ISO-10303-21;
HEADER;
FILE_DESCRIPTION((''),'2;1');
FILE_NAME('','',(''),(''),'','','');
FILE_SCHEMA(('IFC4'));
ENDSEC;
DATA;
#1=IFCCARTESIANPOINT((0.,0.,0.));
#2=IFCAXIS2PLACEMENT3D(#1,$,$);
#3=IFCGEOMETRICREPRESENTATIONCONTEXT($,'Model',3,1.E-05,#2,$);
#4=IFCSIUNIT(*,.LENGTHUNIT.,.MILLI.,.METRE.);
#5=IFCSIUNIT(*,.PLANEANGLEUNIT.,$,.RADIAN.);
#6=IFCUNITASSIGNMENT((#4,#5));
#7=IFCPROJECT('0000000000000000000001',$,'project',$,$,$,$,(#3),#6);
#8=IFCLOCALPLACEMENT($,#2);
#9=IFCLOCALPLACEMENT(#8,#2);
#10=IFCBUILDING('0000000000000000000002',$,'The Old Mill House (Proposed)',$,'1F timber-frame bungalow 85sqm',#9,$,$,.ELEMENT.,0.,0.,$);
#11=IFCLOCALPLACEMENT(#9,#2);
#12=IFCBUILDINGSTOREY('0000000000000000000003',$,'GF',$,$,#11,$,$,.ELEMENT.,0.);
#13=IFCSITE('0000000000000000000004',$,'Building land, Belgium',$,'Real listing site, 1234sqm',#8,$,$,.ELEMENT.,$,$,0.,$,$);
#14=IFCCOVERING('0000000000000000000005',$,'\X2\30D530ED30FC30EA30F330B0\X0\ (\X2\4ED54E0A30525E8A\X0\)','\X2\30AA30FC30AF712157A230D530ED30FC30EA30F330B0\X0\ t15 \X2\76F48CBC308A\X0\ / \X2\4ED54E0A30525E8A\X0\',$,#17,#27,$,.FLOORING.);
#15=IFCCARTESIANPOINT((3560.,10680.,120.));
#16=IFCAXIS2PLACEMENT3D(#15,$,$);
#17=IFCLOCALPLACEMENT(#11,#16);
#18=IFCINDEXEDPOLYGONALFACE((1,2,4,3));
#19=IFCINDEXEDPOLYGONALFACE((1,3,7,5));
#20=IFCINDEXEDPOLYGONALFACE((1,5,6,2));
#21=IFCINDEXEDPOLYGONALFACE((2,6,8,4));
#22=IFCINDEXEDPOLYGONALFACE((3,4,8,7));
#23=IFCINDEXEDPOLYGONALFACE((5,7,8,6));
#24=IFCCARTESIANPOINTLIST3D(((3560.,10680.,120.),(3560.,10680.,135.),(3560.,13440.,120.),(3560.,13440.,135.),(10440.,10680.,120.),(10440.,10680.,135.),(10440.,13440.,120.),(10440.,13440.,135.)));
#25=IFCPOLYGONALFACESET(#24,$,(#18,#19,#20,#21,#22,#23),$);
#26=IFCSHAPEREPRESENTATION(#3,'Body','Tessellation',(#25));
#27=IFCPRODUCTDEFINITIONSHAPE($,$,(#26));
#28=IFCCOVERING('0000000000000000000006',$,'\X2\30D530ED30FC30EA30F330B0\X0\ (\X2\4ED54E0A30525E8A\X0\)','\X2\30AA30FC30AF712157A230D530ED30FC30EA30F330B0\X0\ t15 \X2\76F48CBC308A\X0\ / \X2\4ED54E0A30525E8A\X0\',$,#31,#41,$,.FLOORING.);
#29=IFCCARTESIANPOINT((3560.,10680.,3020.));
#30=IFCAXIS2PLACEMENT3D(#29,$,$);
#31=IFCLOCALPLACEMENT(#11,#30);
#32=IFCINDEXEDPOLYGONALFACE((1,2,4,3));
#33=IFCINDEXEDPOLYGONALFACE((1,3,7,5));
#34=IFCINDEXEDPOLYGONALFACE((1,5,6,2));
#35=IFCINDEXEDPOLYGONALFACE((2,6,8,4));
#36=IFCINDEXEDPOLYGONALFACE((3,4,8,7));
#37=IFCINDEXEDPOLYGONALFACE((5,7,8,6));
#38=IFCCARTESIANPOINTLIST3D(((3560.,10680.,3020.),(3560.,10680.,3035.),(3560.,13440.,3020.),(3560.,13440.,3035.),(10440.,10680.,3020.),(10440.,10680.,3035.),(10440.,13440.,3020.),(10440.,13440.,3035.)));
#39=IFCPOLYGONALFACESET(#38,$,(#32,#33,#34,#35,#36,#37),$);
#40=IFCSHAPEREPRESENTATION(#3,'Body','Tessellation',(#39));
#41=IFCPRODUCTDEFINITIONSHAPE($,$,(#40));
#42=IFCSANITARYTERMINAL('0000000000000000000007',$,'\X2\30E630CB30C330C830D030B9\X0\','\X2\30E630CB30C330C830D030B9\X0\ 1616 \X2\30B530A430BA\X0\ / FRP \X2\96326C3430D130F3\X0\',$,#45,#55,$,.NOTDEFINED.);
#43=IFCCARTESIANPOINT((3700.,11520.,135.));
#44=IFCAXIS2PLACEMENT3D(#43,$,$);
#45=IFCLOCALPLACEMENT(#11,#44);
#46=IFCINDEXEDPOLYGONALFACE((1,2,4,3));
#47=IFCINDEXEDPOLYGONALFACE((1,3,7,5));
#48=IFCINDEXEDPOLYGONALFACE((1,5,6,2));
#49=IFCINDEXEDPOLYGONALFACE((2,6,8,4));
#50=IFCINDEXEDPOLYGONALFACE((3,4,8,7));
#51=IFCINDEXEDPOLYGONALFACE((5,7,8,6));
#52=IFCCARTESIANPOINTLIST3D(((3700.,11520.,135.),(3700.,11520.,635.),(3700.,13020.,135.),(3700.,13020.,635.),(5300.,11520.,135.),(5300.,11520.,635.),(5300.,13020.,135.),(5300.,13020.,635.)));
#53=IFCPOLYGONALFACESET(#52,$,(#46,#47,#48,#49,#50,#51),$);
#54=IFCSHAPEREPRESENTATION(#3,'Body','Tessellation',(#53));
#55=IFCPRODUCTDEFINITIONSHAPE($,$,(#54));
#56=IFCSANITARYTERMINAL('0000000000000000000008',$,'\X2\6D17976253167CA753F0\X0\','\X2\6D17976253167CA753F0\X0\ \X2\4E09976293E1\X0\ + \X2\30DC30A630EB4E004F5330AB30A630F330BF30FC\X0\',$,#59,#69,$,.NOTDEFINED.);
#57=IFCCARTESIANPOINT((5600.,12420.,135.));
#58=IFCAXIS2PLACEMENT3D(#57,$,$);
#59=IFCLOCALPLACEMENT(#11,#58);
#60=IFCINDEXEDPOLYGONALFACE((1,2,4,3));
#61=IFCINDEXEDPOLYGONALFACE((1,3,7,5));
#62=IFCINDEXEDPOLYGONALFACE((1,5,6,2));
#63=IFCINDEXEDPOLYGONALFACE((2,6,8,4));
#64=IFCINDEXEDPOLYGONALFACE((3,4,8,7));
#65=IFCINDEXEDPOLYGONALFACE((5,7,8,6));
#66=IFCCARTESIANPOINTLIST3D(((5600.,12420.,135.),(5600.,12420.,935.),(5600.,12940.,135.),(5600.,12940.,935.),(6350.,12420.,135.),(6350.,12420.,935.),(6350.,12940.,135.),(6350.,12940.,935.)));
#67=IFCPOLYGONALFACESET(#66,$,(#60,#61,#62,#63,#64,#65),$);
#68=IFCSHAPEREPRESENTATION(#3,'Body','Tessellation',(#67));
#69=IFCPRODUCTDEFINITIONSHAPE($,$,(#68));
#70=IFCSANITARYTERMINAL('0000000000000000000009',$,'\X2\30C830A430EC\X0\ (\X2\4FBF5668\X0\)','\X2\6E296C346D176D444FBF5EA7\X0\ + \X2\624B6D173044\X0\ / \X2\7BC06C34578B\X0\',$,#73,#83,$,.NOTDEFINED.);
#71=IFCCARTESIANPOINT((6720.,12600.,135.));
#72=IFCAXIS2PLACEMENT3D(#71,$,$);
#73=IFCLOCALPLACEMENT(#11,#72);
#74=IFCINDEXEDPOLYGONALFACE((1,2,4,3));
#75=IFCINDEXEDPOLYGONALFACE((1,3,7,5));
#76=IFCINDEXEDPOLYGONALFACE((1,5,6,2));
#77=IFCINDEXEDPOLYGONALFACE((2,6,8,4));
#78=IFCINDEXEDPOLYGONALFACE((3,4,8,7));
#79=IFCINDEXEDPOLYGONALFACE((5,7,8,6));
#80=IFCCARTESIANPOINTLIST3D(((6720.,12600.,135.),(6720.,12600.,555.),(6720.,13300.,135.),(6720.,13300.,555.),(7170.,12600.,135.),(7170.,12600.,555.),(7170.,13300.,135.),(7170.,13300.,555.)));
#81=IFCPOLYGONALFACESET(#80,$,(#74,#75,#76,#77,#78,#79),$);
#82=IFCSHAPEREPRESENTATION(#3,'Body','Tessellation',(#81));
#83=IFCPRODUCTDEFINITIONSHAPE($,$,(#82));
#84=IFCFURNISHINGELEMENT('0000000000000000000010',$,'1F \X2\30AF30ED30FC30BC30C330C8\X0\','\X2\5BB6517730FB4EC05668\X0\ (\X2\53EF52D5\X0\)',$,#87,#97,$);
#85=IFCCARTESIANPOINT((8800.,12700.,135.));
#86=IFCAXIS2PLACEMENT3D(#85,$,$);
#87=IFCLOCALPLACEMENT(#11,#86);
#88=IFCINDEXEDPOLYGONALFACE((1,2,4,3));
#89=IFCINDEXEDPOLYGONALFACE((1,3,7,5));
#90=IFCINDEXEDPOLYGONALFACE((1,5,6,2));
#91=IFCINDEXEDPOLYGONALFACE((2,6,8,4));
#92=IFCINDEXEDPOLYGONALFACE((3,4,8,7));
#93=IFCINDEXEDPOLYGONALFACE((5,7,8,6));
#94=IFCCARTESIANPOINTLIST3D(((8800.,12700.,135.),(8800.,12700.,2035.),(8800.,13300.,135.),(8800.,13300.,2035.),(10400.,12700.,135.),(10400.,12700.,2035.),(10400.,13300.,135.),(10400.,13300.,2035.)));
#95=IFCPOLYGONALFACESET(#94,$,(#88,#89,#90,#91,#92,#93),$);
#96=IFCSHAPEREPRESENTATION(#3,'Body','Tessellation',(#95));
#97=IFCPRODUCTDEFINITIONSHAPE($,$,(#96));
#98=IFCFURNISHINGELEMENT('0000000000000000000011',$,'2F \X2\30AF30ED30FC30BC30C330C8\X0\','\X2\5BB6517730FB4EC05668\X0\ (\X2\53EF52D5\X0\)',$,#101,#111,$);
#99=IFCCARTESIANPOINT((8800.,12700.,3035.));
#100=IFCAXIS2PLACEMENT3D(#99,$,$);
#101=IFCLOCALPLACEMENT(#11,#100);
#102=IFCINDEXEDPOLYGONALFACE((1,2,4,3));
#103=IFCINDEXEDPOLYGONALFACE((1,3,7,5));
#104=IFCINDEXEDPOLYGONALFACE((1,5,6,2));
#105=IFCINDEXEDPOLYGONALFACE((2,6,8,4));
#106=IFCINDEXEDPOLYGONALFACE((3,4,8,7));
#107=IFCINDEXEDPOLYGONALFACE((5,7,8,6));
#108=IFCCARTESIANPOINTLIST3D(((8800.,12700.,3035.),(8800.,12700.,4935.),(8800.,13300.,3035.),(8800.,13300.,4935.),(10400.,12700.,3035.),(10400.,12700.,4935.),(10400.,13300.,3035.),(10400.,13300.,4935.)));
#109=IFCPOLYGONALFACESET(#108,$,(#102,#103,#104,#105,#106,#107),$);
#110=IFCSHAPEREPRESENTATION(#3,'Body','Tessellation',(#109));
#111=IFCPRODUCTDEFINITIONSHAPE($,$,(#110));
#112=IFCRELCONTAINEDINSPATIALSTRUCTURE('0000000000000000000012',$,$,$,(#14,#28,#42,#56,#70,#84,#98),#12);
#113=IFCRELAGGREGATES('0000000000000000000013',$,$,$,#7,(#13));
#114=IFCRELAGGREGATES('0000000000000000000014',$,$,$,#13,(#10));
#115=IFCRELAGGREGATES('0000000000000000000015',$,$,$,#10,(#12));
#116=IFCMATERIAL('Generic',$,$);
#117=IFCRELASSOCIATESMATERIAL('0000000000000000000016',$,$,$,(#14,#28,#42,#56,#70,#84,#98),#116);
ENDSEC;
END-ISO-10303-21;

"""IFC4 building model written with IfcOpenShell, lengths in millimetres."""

from ifc_helpers import new_model, si_unit, frame, frame_2d, origin, place, context, project, spatial, rectangle, extrude, material, element, save


model = new_model("IFC4")

# Units and contexts
model_context = context("Model", 3, precision=1e-05, world=origin())
ifc_project = project(units=[si_unit("LENGTHUNIT", "METRE", prefix="MILLI"), si_unit("PLANEANGLEUNIT", "RADIAN")], contexts=[model_context])

# Site, building, storey
site_placement = place(None, origin())
site = spatial("IfcSite", under=ifc_project, at=site_placement, Name="Building land, Belgium", ObjectType="Real listing site, 1234sqm", CompositionType="ELEMENT", RefElevation=0.0)
building_placement = place(site_placement, origin())
building = spatial("IfcBuilding", under=site, at=building_placement, Name="The Old Mill House (Proposed)", ObjectType="1F timber-frame bungalow 85sqm", CompositionType="ELEMENT", ElevationOfRefHeight=0.0, ElevationOfTerrain=0.0)
storey_placement = place(building_placement, origin())
storey = spatial("IfcBuildingStorey", under=building, at=storey_placement, Name="GF", CompositionType="ELEMENT", Elevation=0.0)

# Coverings
ifc_material_1 = material(Name="Generic")
covering_1_placement = place(storey_placement, frame((3560.0, 10680.0, 120.0)))
element("IfcCovering", 1, at=covering_1_placement, inside=storey, material=ifc_material_1, Name="フローリング (仕上げ床)", Description="オーク無垢フローリング t15 直貼り / 仕上げ床", PredefinedType="FLOORING", context=model_context, shape_type="SweptSolid", body=[
    extrude(rectangle(XDim=6880.0, YDim=2760.0, at=frame_2d((3440.0, 1380.0))), frame((3560.0, 10680.0, 120.0)), (0.0, 0.0, 1.0), 15.0),
])
covering_2_placement = place(storey_placement, frame((3560.0, 10680.0, 3020.0)))
element("IfcCovering", 2, at=covering_2_placement, inside=storey, material=ifc_material_1, Name="フローリング (仕上げ床)", Description="オーク無垢フローリング t15 直貼り / 仕上げ床", PredefinedType="FLOORING", context=model_context, shape_type="SweptSolid", body=[
    extrude(rectangle(XDim=6880.0, YDim=2760.0, at=frame_2d((3440.0, 1380.0))), frame((3560.0, 10680.0, 3020.0)), (0.0, 0.0, 1.0), 15.0),
])

# Sanitary terminals
sanitary_terminal_1_placement = place(storey_placement, frame((3700.0, 11520.0, 135.0)))
element("IfcSanitaryTerminal", 3, at=sanitary_terminal_1_placement, inside=storey, material=ifc_material_1, Name="ユニットバス", Description="ユニットバス 1616 サイズ / FRP 防水パン", PredefinedType="NOTDEFINED", context=model_context, shape_type="SweptSolid", body=[
    extrude(rectangle(XDim=1600.0, YDim=1500.0, at=frame_2d((800.0, 750.0))), frame((3700.0, 11520.0, 135.0)), (0.0, 0.0, 1.0), 500.0),
])
sanitary_terminal_2_placement = place(storey_placement, frame((5600.0, 12420.0, 135.0)))
element("IfcSanitaryTerminal", 4, at=sanitary_terminal_2_placement, inside=storey, material=ifc_material_1, Name="洗面化粧台", Description="洗面化粧台 三面鏡 + ボウル一体カウンター", PredefinedType="NOTDEFINED", context=model_context, shape_type="SweptSolid", body=[
    extrude(rectangle(XDim=750.0, YDim=520.0, at=frame_2d((375.0, 260.0))), frame((5600.0, 12420.0, 135.0)), (0.0, 0.0, 1.0), 800.0),
])
sanitary_terminal_3_placement = place(storey_placement, frame((6720.0, 12600.0, 135.0)))
element("IfcSanitaryTerminal", 5, at=sanitary_terminal_3_placement, inside=storey, material=ifc_material_1, Name="トイレ (便器)", Description="温水洗浄便座 + 手洗い / 節水型", PredefinedType="NOTDEFINED", context=model_context, shape_type="SweptSolid", body=[
    extrude(rectangle(XDim=450.0, YDim=700.0, at=frame_2d((225.0, 350.0))), frame((6720.0, 12600.0, 135.0)), (0.0, 0.0, 1.0), 420.0),
])

# Furnishing elements
furnishing_1_placement = place(storey_placement, frame((8800.0, 12700.0, 135.0)))
element("IfcFurnishingElement", 6, at=furnishing_1_placement, inside=storey, material=ifc_material_1, Name="1F クローゼット", Description="家具・什器 (可動)", context=model_context, shape_type="SweptSolid", body=[
    extrude(rectangle(XDim=1600.0, YDim=600.0, at=frame_2d((800.0, 300.0))), frame((8800.0, 12700.0, 135.0)), (0.0, 0.0, 1.0), 1900.0),
])
furnishing_2_placement = place(storey_placement, frame((8800.0, 12700.0, 3035.0)))
element("IfcFurnishingElement", 7, at=furnishing_2_placement, inside=storey, material=ifc_material_1, Name="2F クローゼット", Description="家具・什器 (可動)", context=model_context, shape_type="SweptSolid", body=[
    extrude(rectangle(XDim=1600.0, YDim=600.0, at=frame_2d((800.0, 300.0))), frame((8800.0, 12700.0, 3035.0)), (0.0, 0.0, 1.0), 1900.0),
])

save(model, "model.ifc")
